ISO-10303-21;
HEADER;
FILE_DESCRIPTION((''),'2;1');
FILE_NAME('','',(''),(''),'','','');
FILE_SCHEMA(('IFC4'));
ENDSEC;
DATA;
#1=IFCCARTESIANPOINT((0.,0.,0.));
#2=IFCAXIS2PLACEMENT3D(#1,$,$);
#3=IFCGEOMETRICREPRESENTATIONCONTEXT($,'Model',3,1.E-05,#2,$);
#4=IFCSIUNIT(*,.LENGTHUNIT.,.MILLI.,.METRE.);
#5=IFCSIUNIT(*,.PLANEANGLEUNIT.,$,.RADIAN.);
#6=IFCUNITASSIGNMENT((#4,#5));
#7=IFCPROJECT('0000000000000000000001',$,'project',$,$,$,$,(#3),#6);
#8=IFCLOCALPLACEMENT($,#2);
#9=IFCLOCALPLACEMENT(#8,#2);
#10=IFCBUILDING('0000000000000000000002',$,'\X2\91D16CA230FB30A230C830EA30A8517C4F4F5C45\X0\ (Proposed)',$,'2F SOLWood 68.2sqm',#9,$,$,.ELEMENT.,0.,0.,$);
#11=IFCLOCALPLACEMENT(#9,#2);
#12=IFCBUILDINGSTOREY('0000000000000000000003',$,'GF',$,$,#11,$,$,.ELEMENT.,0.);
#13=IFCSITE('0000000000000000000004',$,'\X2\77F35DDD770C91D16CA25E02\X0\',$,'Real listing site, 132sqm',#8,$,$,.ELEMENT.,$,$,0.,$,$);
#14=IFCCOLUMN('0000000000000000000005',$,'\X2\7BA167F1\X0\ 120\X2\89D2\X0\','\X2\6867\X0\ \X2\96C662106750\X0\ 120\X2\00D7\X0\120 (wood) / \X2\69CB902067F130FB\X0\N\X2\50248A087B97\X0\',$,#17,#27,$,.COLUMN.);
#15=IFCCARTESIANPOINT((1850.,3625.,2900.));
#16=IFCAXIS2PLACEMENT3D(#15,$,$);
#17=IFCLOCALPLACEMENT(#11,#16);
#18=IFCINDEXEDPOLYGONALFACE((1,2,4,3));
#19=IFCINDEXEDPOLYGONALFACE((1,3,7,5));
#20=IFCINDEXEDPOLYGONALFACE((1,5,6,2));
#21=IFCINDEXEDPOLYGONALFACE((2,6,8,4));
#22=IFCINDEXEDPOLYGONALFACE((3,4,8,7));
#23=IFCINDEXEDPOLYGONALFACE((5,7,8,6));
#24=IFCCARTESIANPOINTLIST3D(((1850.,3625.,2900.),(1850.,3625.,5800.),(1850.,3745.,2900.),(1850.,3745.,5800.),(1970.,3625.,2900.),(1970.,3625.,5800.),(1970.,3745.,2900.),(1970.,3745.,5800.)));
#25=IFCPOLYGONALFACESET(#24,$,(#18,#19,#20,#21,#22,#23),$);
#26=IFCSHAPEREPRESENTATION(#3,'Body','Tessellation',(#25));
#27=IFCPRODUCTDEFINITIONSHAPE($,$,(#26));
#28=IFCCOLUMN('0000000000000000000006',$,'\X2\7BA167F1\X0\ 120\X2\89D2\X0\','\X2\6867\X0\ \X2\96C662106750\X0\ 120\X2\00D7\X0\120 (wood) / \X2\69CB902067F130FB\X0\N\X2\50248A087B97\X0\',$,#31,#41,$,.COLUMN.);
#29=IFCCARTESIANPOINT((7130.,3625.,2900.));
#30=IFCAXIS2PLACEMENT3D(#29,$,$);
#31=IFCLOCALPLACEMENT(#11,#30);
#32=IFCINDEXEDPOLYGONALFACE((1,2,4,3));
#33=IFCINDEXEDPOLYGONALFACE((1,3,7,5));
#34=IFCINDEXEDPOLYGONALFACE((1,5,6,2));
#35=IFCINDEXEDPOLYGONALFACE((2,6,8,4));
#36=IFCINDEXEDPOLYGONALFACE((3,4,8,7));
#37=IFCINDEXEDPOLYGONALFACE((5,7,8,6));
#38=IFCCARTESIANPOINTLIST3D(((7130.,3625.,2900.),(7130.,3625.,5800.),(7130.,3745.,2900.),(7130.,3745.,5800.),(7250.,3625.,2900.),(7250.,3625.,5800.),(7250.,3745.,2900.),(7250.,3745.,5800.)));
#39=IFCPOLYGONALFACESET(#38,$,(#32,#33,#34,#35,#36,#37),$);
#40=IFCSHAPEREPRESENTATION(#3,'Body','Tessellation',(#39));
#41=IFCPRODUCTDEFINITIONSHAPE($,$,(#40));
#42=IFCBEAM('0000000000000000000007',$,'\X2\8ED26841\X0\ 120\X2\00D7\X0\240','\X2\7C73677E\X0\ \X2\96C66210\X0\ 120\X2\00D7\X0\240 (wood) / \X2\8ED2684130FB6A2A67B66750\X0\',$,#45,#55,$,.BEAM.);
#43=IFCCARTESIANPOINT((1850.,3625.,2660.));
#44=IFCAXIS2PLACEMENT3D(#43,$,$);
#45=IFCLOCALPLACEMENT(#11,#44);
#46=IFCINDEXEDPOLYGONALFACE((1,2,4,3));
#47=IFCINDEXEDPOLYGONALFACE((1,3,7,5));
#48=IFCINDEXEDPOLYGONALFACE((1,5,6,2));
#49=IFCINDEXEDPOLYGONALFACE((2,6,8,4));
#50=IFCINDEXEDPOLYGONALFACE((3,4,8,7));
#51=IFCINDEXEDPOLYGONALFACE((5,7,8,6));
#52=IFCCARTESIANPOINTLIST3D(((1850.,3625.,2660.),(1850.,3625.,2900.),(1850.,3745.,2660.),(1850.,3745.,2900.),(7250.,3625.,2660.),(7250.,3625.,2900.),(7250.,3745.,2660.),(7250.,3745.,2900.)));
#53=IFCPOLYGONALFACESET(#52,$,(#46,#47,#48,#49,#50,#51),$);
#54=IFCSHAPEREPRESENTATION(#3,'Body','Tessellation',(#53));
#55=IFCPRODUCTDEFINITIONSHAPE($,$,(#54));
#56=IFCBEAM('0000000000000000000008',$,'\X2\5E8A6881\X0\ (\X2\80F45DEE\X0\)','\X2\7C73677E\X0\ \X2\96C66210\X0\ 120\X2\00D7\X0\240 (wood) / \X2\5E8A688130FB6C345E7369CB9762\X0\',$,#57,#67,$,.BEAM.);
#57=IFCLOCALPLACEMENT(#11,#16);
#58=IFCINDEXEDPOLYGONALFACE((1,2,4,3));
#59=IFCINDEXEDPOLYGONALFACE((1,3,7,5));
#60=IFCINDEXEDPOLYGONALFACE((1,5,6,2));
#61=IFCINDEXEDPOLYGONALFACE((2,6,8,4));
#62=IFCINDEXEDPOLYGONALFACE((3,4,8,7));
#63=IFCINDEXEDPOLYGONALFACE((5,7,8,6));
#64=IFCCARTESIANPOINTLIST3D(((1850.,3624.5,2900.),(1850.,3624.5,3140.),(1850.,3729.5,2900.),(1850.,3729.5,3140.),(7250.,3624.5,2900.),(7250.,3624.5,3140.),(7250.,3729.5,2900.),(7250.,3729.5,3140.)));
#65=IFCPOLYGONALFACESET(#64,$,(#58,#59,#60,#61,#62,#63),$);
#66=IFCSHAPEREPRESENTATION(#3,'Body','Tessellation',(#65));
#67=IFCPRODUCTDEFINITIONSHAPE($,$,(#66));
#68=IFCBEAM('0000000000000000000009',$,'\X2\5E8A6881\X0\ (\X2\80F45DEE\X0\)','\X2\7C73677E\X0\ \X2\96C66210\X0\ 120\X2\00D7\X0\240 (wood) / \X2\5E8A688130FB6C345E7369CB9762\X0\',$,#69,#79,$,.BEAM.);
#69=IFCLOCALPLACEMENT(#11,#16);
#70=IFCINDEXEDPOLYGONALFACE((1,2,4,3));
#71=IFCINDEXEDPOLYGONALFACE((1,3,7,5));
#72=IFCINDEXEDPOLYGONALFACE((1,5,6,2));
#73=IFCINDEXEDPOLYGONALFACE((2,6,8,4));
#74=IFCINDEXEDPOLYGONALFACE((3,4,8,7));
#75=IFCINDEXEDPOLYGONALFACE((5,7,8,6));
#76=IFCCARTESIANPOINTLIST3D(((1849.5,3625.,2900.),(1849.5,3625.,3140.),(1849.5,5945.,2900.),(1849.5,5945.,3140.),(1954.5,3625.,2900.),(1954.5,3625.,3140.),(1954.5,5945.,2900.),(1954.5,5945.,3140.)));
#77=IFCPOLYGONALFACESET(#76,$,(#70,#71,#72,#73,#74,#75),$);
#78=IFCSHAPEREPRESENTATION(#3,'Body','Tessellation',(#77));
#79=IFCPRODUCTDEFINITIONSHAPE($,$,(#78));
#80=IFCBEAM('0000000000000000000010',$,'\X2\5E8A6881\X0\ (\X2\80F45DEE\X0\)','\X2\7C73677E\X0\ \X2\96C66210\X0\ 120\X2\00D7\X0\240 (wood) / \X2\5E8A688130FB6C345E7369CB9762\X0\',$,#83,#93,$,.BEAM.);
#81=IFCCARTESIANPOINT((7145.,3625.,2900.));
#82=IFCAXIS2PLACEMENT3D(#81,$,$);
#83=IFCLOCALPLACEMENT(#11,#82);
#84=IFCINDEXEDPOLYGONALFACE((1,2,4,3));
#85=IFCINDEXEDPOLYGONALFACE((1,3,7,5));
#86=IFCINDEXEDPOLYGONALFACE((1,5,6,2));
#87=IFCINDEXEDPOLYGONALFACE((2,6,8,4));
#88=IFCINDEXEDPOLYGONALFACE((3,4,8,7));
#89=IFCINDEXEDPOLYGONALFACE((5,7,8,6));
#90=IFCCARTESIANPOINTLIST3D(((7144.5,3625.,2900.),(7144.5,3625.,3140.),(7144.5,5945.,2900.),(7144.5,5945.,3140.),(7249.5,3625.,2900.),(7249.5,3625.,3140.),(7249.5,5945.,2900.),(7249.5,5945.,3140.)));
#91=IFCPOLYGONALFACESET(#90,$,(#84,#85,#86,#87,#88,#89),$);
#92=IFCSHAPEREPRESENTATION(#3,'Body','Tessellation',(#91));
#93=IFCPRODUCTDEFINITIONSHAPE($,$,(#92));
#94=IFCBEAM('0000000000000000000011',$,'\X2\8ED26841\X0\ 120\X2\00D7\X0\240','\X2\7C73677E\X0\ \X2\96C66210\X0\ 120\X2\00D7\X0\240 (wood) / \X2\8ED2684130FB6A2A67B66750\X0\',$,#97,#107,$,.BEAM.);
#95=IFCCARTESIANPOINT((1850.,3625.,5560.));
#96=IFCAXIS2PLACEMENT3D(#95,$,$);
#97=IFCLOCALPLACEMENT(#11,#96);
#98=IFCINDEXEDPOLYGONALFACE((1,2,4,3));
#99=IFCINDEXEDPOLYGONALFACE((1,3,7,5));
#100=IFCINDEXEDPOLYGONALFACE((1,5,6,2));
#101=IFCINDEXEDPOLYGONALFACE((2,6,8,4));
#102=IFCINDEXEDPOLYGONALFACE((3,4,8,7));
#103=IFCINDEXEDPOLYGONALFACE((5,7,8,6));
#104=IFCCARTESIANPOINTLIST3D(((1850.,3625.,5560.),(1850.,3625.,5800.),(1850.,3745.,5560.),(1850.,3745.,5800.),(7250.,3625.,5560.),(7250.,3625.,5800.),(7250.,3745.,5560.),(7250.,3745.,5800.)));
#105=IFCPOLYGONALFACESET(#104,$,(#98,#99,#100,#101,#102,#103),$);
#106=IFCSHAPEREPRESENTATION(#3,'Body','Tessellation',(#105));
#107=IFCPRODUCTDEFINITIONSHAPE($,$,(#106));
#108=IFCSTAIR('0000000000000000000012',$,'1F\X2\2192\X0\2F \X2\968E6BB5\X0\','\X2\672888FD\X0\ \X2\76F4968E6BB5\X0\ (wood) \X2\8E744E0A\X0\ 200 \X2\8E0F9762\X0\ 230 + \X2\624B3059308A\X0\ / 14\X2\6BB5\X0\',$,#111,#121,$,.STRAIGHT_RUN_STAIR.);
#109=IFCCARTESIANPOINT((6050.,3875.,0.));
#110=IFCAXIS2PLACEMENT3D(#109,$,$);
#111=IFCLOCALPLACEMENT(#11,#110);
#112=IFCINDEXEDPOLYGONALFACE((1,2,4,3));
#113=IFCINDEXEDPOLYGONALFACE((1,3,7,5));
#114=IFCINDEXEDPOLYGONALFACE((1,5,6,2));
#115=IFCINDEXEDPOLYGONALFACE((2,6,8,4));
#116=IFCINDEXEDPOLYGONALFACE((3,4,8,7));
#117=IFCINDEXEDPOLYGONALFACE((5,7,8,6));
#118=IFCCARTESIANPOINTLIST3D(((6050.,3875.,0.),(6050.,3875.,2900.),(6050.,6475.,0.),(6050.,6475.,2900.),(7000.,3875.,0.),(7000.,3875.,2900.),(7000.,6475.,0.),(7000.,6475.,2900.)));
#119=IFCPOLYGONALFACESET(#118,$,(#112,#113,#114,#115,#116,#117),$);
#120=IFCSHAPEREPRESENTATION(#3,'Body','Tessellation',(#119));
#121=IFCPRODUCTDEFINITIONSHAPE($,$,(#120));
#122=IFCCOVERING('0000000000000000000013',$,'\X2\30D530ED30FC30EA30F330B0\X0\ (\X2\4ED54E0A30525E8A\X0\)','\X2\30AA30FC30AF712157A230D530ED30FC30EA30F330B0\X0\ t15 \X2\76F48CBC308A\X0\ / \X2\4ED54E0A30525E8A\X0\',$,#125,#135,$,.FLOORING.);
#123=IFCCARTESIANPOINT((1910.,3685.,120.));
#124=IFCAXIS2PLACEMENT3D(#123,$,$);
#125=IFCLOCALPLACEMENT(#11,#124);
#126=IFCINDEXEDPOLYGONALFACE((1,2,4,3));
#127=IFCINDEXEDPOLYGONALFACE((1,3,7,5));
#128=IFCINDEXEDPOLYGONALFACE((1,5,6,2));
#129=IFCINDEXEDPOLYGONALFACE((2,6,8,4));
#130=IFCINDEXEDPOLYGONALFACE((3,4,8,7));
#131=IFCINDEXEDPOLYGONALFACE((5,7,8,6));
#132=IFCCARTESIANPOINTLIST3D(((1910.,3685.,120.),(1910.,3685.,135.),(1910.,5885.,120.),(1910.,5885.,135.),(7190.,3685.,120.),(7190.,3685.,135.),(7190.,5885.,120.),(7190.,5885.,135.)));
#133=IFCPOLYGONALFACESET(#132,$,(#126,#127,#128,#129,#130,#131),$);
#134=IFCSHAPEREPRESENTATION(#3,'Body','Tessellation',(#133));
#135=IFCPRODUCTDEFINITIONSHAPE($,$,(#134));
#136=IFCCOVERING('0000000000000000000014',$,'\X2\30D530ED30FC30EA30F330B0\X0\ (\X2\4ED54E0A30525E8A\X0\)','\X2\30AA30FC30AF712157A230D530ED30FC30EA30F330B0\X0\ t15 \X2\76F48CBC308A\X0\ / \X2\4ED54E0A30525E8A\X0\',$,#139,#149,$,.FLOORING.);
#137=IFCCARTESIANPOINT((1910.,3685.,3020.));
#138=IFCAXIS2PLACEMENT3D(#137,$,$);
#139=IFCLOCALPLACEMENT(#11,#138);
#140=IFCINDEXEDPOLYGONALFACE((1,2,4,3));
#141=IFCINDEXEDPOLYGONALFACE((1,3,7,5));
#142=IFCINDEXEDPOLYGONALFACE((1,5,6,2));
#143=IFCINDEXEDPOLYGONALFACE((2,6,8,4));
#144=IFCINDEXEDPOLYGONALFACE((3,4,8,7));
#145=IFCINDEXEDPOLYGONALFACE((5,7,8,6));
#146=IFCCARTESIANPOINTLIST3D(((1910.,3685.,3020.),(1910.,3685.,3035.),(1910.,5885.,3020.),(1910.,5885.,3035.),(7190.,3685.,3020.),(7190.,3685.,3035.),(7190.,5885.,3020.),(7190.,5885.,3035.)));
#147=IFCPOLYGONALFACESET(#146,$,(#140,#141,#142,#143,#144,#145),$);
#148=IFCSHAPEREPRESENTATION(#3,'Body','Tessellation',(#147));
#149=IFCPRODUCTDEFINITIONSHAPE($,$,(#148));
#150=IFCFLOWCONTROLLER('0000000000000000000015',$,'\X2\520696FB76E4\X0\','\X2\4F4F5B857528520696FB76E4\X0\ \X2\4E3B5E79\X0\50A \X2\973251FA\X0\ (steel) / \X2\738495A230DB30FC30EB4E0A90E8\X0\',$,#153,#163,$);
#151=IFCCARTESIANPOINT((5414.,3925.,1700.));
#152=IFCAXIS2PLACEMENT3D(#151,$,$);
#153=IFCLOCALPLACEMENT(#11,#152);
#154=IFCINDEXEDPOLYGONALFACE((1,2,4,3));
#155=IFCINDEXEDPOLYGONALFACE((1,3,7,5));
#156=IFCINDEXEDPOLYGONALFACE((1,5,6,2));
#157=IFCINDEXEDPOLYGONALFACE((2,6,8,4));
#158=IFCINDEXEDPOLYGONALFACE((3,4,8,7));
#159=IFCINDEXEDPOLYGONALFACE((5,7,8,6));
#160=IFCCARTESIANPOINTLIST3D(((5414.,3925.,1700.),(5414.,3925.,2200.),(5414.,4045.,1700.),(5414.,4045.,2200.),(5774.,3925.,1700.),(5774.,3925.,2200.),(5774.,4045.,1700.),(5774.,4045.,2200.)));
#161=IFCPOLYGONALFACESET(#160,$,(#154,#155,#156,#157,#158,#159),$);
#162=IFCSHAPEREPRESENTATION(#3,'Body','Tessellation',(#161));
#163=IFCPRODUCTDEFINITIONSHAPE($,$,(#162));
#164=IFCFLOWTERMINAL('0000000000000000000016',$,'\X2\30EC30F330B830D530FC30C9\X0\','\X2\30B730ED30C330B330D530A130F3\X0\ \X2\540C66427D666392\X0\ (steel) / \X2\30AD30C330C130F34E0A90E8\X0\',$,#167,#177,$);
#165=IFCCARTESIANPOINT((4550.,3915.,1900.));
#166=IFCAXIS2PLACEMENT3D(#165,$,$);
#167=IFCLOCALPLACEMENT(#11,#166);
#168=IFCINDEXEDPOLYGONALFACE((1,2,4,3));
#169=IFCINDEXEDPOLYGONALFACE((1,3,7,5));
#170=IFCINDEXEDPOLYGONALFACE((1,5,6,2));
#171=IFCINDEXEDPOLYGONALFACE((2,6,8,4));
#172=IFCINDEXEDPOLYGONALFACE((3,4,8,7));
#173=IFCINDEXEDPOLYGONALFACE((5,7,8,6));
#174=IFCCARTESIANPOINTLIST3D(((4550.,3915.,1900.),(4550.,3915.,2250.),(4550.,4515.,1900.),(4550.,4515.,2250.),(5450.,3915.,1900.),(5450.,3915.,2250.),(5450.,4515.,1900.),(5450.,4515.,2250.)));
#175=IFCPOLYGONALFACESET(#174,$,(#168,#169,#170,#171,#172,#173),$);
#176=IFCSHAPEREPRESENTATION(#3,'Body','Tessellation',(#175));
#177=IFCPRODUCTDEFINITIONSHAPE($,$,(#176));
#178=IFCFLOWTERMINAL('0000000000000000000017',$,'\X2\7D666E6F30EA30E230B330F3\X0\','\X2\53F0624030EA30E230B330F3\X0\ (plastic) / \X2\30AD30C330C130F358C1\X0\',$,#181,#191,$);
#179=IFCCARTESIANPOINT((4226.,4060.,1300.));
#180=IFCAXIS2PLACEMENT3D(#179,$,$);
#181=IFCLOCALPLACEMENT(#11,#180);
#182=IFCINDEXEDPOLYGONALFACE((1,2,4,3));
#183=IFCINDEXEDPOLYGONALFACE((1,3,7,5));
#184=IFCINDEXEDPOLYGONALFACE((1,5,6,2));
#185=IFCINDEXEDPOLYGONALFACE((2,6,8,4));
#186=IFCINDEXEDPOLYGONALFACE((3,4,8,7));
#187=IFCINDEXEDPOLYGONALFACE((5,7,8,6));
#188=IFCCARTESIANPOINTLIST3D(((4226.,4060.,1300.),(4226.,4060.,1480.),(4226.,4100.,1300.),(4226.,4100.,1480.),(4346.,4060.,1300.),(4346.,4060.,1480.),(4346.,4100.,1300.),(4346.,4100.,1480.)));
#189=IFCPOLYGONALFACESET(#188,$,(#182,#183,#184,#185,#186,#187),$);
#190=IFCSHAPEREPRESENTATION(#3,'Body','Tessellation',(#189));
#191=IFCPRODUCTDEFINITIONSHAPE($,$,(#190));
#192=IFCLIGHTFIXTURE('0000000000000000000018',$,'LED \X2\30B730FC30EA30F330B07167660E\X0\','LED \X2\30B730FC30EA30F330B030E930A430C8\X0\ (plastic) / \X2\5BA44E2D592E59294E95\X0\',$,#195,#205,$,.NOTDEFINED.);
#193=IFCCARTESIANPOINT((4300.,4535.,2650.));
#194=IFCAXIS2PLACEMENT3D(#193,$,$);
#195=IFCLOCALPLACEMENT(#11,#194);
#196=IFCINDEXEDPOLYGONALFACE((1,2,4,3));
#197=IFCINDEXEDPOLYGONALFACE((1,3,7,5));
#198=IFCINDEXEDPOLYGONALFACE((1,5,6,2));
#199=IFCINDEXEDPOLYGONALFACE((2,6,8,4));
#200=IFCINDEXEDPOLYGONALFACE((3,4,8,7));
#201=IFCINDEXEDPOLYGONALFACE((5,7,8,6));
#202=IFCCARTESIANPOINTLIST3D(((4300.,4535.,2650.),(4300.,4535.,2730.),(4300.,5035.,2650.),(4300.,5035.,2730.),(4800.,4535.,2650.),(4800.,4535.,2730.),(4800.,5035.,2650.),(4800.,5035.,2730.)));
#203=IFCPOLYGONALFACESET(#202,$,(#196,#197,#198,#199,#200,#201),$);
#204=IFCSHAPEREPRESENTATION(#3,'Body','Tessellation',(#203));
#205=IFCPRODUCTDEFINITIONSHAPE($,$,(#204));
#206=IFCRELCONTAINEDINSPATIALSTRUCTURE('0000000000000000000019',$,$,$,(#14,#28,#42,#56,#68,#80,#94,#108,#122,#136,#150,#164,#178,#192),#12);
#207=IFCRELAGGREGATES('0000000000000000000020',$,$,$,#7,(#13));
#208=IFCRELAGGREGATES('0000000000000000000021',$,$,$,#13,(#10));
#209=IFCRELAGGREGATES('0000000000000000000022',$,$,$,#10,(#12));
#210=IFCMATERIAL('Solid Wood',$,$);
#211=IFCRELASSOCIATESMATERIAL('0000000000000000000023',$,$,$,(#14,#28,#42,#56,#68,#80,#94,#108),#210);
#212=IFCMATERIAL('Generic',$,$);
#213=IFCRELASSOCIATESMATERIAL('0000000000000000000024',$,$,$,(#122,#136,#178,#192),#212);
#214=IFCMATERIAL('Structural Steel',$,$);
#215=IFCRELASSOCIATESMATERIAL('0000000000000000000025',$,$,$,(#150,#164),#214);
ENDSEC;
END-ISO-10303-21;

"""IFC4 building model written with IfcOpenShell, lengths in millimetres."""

from ifc_helpers import new_model, si_unit, frame, frame_2d, origin, place, context, project, spatial, rectangle, extrude, material, element, save


model = new_model("IFC4")

# Units and contexts
model_context = context("Model", 3, precision=1e-05, world=origin())
ifc_project = project(units=[si_unit("LENGTHUNIT", "METRE", prefix="MILLI"), si_unit("PLANEANGLEUNIT", "RADIAN")], contexts=[model_context])

# Site, building, storey
site_placement = place(None, origin())
site = spatial("IfcSite", under=ifc_project, at=site_placement, Name="石川県金沢市", ObjectType="Real listing site, 132sqm", CompositionType="ELEMENT", RefElevation=0.0)
building_placement = place(site_placement, origin())
building = spatial("IfcBuilding", under=site, at=building_placement, Name="金沢・アトリエ兼住居 (Proposed)", ObjectType="2F SOLWood 68.2sqm", CompositionType="ELEMENT", ElevationOfRefHeight=0.0, ElevationOfTerrain=0.0)
storey_placement = place(building_placement, origin())
storey = spatial("IfcBuildingStorey", under=building, at=storey_placement, Name="GF", CompositionType="ELEMENT", Elevation=0.0)

# Columns
ifc_material_1 = material(Name="Solid Wood")
column_1_placement = place(storey_placement, frame((1850.0, 3625.0, 2900.0)))
element("IfcColumn", 1, at=column_1_placement, inside=storey, material=ifc_material_1, Name="管柱 120角", Description="桧 集成材 120×120 (wood) / 構造柱・N値計算", PredefinedType="COLUMN", context=model_context, shape_type="SweptSolid", body=[
    extrude(rectangle(XDim=120.0, YDim=120.0, at=frame_2d((60.0, 60.0))), frame((1850.0, 3625.0, 2900.0)), (0.0, 0.0, 1.0), 2900.0),
])
column_2_placement = place(storey_placement, frame((7130.0, 3625.0, 2900.0)))
element("IfcColumn", 2, at=column_2_placement, inside=storey, material=ifc_material_1, Name="管柱 120角", Description="桧 集成材 120×120 (wood) / 構造柱・N値計算", PredefinedType="COLUMN", context=model_context, shape_type="SweptSolid", body=[
    extrude(rectangle(XDim=120.0, YDim=120.0, at=frame_2d((60.0, 60.0))), frame((7130.0, 3625.0, 2900.0)), (0.0, 0.0, 1.0), 2900.0),
])

# Beams
beam_1_placement = place(storey_placement, frame((1850.0, 3625.0, 2660.0)))
element("IfcBeam", 3, at=beam_1_placement, inside=storey, material=ifc_material_1, Name="軒桁 120×240", Description="米松 集成 120×240 (wood) / 軒桁・横架材", PredefinedType="BEAM", context=model_context, shape_type="SweptSolid", body=[
    extrude(rectangle(XDim=5400.0, YDim=120.0, at=frame_2d((2700.0, 60.0))), frame((1850.0, 3625.0, 2660.0)), (0.0, 0.0, 1.0), 240.0),
])
beam_2_placement = place(storey_placement, frame((1850.0, 3625.0, 2900.0)))
element("IfcBeam", 4, at=beam_2_placement, inside=storey, material=ifc_material_1, Name="床梁 (胴差)", Description="米松 集成 120×240 (wood) / 床梁・水平構面", PredefinedType="BEAM", context=model_context, shape_type="SweptSolid", body=[
    extrude(rectangle(XDim=5400.0, YDim=105.0, at=frame_2d((2700.0, 52.0))), frame((1850.0, 3625.0, 2900.0)), (0.0, 0.0, 1.0), 240.0),
])
beam_3_placement = place(storey_placement, frame((1850.0, 3625.0, 2900.0)))
element("IfcBeam", 5, at=beam_3_placement, inside=storey, material=ifc_material_1, Name="床梁 (胴差)", Description="米松 集成 120×240 (wood) / 床梁・水平構面", PredefinedType="BEAM", context=model_context, shape_type="SweptSolid", body=[
    extrude(rectangle(XDim=105.0, YDim=2320.0, at=frame_2d((52.0, 1160.0))), frame((1850.0, 3625.0, 2900.0)), (0.0, 0.0, 1.0), 240.0),
])
beam_4_placement = place(storey_placement, frame((7145.0, 3625.0, 2900.0)))
element("IfcBeam", 6, at=beam_4_placement, inside=storey, material=ifc_material_1, Name="床梁 (胴差)", Description="米松 集成 120×240 (wood) / 床梁・水平構面", PredefinedType="BEAM", context=model_context, shape_type="SweptSolid", body=[
    extrude(rectangle(XDim=105.0, YDim=2320.0, at=frame_2d((52.0, 1160.0))), frame((7145.0, 3625.0, 2900.0)), (0.0, 0.0, 1.0), 240.0),
])
beam_5_placement = place(storey_placement, frame((1850.0, 3625.0, 5560.0)))
element("IfcBeam", 7, at=beam_5_placement, inside=storey, material=ifc_material_1, Name="軒桁 120×240", Description="米松 集成 120×240 (wood) / 軒桁・横架材", PredefinedType="BEAM", context=model_context, shape_type="SweptSolid", body=[
    extrude(rectangle(XDim=5400.0, YDim=120.0, at=frame_2d((2700.0, 60.0))), frame((1850.0, 3625.0, 5560.0)), (0.0, 0.0, 1.0), 240.0),
])

# Stair
stair_placement = place(storey_placement, frame((6050.0, 3875.0, 0.0)))
element("IfcStair", 8, at=stair_placement, inside=storey, material=ifc_material_1, Name="1F→2F 階段", Description="木製 直階段 (wood) 蹴上 200 踏面 230 + 手すり / 14段", PredefinedType="STRAIGHT_RUN_STAIR", context=model_context, shape_type="SweptSolid", body=[
    extrude(rectangle(XDim=950.0, YDim=2600.0, at=frame_2d((475.0, 1300.0))), frame((6050.0, 3875.0, 0.0)), (0.0, 0.0, 1.0), 2900.0),
])

# Coverings
ifc_material_2 = material(Name="Generic")
covering_1_placement = place(storey_placement, frame((1910.0, 3685.0, 120.0)))
element("IfcCovering", 9, at=covering_1_placement, inside=storey, material=ifc_material_2, Name="フローリング (仕上げ床)", Description="オーク無垢フローリング t15 直貼り / 仕上げ床", PredefinedType="FLOORING", context=model_context, shape_type="SweptSolid", body=[
    extrude(rectangle(XDim=5280.0, YDim=2200.0, at=frame_2d((2640.0, 1100.0))), frame((1910.0, 3685.0, 120.0)), (0.0, 0.0, 1.0), 15.0),
])
covering_2_placement = place(storey_placement, frame((1910.0, 3685.0, 3020.0)))
element("IfcCovering", 10, at=covering_2_placement, inside=storey, material=ifc_material_2, Name="フローリング (仕上げ床)", Description="オーク無垢フローリング t15 直貼り / 仕上げ床", PredefinedType="FLOORING", context=model_context, shape_type="SweptSolid", body=[
    extrude(rectangle(XDim=5280.0, YDim=2200.0, at=frame_2d((2640.0, 1100.0))), frame((1910.0, 3685.0, 3020.0)), (0.0, 0.0, 1.0), 15.0),
])

# Flow controller
ifc_material_3 = material(Name="Structural Steel")
flow_controller_placement = place(storey_placement, frame((5414.0, 3925.0, 1700.0)))
element("IfcFlowController", 11, at=flow_controller_placement, inside=storey, material=ifc_material_3, Name="分電盤", Description="住宅用分電盤 主幹50A 露出 (steel) / 玄関ホール上部", context=model_context, shape_type="SweptSolid", body=[
    extrude(rectangle(XDim=360.0, YDim=120.0, at=frame_2d((180.0, 60.0))), frame((5414.0, 3925.0, 1700.0)), (0.0, 0.0, 1.0), 500.0),
])

# Flow terminals
flow_terminal_1_placement = place(storey_placement, frame((4550.0, 3915.0, 1900.0)))
element("IfcFlowTerminal", 12, at=flow_terminal_1_placement, inside=storey, material=ifc_material_3, Name="レンジフード", Description="シロッコファン 同時給排 (steel) / キッチン上部", context=model_context, shape_type="SweptSolid", body=[
    extrude(rectangle(XDim=900.0, YDim=600.0, at=frame_2d((450.0, 300.0))), frame((4550.0, 3915.0, 1900.0)), (0.0, 0.0, 1.0), 350.0),
])
flow_terminal_2_placement = place(storey_placement, frame((4226.0, 4060.0, 1300.0)))
element("IfcFlowTerminal", 13, at=flow_terminal_2_placement, inside=storey, material=ifc_material_2, Name="給湯リモコン", Description="台所リモコン (plastic) / キッチン壁", context=model_context, shape_type="SweptSolid", body=[
    extrude(rectangle(XDim=120.0, YDim=40.0, at=frame_2d((60.0, 20.0))), frame((4226.0, 4060.0, 1300.0)), (0.0, 0.0, 1.0), 180.0),
])

# Light fixture
light_fixture_1_placement = place(storey_placement, frame((4300.0, 4535.0, 2650.0)))
element("IfcLightFixture", 14, at=light_fixture_1_placement, inside=storey, material=ifc_material_2, Name="LED シーリング照明", Description="LED シーリングライト (plastic) / 室中央天井", PredefinedType="NOTDEFINED", context=model_context, shape_type="SweptSolid", body=[
    extrude(rectangle(XDim=500.0, YDim=500.0, at=frame_2d((250.0, 250.0))), frame((4300.0, 4535.0, 2650.0)), (0.0, 0.0, 1.0), 80.0),
])

save(model, "model.ifc")
